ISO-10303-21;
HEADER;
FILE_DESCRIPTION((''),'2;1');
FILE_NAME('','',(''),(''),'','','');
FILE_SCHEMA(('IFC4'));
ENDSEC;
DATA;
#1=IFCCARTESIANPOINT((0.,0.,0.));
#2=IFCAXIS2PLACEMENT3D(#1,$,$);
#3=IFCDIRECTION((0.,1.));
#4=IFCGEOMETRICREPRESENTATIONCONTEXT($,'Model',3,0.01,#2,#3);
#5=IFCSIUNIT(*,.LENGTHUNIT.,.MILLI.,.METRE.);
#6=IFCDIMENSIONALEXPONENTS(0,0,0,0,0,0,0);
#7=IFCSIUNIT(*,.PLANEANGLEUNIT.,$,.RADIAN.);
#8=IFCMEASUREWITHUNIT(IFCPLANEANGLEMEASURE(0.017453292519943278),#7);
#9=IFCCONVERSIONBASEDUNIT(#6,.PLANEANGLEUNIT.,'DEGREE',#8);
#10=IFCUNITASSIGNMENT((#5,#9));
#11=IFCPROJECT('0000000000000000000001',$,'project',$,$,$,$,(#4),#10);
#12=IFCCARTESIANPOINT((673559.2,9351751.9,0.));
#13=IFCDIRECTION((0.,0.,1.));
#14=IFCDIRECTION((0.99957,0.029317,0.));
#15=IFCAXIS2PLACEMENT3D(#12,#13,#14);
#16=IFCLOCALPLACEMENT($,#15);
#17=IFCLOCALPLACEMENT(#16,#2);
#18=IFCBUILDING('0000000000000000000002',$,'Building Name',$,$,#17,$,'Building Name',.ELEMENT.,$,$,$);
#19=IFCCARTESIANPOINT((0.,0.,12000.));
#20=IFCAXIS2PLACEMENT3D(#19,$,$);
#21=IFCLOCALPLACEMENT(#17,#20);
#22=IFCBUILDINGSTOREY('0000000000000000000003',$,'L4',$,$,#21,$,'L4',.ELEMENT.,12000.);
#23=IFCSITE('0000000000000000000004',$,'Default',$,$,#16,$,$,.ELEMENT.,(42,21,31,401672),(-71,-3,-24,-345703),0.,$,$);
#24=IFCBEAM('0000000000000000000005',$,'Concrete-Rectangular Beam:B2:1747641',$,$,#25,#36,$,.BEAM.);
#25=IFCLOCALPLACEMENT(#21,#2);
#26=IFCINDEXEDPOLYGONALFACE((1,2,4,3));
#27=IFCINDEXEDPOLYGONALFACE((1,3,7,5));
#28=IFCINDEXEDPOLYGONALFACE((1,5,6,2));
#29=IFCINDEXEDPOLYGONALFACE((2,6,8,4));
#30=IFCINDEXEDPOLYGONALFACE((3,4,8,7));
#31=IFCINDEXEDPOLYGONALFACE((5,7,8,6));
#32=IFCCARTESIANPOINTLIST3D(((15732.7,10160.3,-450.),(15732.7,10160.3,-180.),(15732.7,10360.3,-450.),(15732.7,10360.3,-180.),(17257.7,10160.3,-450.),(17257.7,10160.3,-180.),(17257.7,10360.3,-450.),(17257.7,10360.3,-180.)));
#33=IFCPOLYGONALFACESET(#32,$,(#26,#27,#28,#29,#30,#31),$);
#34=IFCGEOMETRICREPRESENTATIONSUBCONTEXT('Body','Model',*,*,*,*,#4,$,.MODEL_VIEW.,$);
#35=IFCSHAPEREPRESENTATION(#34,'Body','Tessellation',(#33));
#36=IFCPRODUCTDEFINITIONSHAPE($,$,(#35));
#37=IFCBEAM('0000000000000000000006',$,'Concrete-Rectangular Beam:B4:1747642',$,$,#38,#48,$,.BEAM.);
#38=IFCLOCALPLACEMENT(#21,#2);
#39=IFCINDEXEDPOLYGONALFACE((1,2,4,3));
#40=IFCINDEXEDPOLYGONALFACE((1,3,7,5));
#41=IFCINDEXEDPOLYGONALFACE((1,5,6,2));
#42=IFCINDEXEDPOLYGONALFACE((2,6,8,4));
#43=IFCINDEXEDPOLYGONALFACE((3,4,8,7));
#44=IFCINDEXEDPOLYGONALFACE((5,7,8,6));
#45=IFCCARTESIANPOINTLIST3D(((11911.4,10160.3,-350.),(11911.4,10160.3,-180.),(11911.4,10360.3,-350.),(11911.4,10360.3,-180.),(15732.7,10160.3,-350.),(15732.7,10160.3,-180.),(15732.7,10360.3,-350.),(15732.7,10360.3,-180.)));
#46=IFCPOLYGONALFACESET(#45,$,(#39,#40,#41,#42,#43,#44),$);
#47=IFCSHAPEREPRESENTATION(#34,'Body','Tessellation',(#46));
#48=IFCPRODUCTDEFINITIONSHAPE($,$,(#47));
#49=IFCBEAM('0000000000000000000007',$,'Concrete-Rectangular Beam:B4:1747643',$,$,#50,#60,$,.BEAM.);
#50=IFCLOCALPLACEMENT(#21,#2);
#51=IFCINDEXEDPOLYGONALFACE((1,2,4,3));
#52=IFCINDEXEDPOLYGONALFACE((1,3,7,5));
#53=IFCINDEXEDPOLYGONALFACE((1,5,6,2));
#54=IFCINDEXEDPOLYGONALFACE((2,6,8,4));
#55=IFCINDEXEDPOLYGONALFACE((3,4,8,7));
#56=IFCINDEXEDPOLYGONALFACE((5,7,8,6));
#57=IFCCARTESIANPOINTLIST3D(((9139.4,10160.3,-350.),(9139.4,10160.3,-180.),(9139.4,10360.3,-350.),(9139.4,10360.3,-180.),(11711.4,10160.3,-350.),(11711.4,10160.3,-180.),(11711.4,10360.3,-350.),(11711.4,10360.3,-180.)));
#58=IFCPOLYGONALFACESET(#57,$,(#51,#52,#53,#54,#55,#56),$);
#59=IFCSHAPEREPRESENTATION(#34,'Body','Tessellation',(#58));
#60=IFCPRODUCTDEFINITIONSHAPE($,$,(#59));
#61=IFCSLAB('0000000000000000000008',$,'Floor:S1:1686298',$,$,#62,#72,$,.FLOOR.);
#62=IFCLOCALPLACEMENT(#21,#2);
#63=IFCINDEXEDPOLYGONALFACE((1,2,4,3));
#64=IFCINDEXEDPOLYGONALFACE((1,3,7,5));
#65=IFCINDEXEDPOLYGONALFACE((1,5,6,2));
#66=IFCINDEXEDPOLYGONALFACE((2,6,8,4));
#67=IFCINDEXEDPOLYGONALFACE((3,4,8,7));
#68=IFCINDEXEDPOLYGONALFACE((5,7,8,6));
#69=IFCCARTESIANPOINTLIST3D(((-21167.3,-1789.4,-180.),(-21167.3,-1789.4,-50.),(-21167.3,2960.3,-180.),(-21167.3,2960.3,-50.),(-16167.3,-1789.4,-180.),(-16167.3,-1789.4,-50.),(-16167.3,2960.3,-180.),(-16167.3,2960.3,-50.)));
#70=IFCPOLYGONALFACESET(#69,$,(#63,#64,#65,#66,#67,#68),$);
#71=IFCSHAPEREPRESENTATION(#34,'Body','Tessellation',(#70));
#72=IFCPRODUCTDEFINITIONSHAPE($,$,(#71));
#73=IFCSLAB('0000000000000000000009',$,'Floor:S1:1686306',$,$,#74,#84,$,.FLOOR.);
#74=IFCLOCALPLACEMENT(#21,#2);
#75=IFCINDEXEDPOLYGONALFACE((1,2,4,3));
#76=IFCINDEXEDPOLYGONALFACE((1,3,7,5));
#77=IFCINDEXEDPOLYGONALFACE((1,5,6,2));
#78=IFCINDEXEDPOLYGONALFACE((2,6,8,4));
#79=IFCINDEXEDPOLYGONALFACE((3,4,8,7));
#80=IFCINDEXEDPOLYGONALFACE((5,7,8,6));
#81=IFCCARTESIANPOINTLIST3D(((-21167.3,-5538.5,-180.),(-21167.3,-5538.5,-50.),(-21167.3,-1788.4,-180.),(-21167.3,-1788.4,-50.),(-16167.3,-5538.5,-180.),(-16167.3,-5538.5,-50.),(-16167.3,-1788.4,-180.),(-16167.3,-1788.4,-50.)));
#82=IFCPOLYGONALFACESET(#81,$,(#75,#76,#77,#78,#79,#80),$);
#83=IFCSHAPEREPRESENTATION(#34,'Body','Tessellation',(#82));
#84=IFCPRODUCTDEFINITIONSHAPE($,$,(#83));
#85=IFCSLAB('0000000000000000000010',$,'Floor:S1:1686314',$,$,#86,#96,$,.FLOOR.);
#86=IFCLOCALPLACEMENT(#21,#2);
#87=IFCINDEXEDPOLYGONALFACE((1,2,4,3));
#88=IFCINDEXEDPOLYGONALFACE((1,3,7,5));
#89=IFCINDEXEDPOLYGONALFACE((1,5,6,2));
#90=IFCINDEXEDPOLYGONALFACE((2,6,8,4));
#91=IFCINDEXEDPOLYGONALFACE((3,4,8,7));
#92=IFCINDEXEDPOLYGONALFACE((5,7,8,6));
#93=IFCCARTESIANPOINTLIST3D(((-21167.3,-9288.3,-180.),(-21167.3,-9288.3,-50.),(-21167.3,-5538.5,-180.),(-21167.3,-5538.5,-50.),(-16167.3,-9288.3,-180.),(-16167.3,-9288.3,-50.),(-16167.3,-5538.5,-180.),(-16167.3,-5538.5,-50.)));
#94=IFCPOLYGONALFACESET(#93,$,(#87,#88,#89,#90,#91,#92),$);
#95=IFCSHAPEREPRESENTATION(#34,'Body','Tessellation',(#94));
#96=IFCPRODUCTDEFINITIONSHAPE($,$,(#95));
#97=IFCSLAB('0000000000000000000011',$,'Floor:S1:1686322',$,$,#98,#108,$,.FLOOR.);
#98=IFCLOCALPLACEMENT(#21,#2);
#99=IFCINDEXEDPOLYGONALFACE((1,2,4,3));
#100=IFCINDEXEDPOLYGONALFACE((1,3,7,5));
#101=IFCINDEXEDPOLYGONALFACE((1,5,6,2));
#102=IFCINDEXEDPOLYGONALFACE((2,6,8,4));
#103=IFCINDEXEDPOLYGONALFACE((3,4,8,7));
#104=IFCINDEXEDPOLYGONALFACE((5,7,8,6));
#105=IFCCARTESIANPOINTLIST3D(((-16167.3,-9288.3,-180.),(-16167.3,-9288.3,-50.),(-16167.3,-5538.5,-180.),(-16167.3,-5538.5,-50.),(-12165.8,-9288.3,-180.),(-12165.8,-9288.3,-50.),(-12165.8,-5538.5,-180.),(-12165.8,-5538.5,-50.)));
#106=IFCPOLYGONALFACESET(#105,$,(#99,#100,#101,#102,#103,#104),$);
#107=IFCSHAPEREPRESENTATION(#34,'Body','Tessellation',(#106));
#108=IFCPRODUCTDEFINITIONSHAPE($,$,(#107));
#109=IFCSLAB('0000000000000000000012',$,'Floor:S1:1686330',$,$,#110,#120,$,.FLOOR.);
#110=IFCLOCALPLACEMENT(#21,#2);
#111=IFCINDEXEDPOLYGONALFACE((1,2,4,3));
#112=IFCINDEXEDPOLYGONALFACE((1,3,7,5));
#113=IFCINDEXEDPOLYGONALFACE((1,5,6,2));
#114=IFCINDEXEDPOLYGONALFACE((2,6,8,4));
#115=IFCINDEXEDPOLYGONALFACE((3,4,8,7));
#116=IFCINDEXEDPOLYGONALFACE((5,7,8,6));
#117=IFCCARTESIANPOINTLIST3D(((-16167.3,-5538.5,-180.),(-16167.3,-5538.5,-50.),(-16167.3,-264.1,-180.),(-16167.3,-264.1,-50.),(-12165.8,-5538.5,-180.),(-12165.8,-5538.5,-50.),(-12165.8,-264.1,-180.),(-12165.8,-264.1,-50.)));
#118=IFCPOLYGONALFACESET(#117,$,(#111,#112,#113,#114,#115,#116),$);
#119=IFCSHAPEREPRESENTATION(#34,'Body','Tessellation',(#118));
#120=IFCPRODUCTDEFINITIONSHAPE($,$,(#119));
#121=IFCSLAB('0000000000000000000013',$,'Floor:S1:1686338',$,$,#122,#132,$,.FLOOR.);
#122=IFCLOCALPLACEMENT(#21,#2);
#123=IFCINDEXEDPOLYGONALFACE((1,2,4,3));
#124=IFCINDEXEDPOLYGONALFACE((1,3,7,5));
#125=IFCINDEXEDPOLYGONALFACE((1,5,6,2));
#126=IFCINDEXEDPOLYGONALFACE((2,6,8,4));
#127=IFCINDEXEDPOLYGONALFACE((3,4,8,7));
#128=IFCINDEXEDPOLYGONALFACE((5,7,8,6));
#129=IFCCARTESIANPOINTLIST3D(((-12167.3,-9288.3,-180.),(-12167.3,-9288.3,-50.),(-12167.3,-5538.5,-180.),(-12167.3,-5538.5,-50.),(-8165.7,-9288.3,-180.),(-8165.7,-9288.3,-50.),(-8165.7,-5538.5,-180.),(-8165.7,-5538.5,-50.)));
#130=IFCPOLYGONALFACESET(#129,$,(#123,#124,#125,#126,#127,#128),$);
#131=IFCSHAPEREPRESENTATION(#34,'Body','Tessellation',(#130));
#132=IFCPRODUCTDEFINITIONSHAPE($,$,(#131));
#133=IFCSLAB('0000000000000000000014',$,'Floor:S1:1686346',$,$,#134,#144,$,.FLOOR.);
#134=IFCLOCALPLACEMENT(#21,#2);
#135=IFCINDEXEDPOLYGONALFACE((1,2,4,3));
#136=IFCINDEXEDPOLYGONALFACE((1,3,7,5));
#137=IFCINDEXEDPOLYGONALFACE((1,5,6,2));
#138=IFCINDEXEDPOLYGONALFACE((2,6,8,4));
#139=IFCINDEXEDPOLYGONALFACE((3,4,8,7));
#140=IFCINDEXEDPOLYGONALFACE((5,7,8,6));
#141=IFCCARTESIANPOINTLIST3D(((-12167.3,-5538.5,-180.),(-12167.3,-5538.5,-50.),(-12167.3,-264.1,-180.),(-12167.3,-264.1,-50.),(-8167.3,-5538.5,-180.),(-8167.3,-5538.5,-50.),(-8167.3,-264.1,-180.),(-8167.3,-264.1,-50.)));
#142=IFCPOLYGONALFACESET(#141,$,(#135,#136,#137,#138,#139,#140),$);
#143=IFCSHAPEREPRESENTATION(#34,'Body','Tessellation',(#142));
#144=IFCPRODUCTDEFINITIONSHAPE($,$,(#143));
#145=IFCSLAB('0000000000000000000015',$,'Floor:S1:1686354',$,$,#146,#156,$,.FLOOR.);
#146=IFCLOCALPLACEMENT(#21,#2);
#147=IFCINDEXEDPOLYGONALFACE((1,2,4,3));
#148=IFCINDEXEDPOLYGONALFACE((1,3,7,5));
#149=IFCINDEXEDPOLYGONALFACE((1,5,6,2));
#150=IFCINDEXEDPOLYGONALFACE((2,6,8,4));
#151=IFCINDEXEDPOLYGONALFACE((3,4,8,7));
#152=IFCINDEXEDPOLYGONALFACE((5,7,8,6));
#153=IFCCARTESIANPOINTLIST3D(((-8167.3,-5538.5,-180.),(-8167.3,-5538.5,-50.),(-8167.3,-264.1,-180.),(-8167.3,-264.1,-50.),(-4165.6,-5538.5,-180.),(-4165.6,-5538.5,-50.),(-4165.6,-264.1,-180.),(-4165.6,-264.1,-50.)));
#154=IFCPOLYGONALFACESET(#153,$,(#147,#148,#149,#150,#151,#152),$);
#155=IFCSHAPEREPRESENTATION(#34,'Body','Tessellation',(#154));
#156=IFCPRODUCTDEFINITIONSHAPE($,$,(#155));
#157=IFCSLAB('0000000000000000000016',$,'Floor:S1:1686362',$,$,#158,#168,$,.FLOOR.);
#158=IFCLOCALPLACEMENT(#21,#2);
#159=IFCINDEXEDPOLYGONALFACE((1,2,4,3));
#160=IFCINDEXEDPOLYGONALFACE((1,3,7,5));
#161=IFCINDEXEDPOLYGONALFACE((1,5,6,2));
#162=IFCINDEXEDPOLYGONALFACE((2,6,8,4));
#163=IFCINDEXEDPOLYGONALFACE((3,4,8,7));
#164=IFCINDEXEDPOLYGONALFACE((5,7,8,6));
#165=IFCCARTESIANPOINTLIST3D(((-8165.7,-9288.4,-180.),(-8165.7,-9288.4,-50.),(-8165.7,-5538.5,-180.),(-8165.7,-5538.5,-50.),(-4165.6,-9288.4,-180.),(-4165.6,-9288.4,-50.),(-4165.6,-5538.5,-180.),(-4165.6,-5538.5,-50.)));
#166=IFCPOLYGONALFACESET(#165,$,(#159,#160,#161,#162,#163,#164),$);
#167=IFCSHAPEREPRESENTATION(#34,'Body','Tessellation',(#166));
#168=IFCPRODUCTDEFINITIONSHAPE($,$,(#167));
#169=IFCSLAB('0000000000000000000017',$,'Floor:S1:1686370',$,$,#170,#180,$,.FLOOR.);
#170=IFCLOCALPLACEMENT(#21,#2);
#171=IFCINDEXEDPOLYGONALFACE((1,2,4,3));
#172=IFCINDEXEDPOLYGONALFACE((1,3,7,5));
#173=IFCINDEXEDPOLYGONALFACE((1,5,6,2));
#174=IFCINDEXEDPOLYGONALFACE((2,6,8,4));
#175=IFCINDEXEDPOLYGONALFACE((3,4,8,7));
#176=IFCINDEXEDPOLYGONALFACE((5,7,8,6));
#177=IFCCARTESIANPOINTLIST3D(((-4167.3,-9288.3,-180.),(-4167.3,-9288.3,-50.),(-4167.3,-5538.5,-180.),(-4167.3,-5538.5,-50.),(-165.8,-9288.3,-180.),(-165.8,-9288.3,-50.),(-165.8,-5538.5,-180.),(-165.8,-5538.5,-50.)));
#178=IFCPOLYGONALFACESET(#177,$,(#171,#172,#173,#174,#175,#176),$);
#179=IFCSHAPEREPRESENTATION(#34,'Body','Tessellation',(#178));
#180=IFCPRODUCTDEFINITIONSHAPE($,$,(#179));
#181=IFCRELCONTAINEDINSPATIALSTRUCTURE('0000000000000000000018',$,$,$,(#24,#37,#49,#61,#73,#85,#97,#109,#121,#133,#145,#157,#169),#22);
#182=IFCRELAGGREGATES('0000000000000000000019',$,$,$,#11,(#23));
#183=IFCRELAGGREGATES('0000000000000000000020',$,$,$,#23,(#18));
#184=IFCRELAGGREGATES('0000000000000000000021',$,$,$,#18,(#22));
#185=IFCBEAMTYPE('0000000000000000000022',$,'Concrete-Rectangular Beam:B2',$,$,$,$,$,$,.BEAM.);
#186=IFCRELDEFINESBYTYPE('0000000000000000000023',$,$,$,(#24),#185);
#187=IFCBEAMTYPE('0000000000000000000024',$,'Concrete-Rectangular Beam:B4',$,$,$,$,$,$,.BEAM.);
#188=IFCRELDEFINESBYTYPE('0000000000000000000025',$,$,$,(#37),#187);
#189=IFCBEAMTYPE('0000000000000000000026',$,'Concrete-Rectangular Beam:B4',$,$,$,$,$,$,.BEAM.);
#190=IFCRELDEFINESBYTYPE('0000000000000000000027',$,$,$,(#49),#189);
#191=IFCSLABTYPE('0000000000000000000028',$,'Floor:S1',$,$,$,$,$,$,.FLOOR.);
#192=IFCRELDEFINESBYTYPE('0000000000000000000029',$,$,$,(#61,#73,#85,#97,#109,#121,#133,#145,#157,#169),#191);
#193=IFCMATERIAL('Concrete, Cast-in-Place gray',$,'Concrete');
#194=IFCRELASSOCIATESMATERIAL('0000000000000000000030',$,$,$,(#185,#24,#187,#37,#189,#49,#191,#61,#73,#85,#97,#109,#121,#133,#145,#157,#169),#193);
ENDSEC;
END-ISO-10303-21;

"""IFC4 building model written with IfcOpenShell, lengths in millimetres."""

from ifc_helpers import new_model, entity, si_unit, converted_unit, direction, frame, origin, place, context, subcontext, project, spatial, indexed_curve, outline, extrude, source, transform, mapped, material, type_object, type_shapes, element, save


model = new_model("IFC4")

# Units and contexts
model_context = context("Model", 3, precision=0.01, world=origin(), true_north=direction((0.0, 1.0)))
body_context = subcontext(model_context, "Body", "Model", "MODEL_VIEW")
ifc_project = project(units=[si_unit("LENGTHUNIT", "METRE", prefix="MILLI"), converted_unit("PLANEANGLEUNIT", "DEGREE", entity("IfcPlaneAngleMeasure", 0.017453292519943278), si_unit("PLANEANGLEUNIT", "RADIAN"), dimensions=[0, 0, 0, 0, 0, 0, 0])], contexts=[model_context])

# Site, building, storey
site_placement = place(None, frame((673559.2, 9351751.9, 0.0), z_axis=(0.0, 0.0, 1.0), x_axis=(0.99957, 0.029317, 0.0)))
site = spatial("IfcSite", under=ifc_project, at=site_placement, Name="Default", CompositionType="ELEMENT", RefLatitude=(42, 21, 31, 401672), RefLongitude=(-71, -3, -24, -345703), RefElevation=0.0)
building_placement = place(site_placement, origin())
building = spatial("IfcBuilding", under=site, at=building_placement, Name="Building Name", LongName="Building Name", CompositionType="ELEMENT")
storey_placement = place(building_placement, frame((0.0, 0.0, 12000.0)))
storey = spatial("IfcBuildingStorey", under=building, at=storey_placement, Name="L4", LongName="L4", CompositionType="ELEMENT", Elevation=12000.0)

# Beams
ifc_material_1 = material(Name="Concrete, Cast-in-Place gray", Category="Concrete")
beam_type_1 = type_object("IfcBeamType", Name="Concrete-Rectangular Beam:B2", PredefinedType="BEAM", material=ifc_material_1)
shared_shape_1 = source(origin(), body_context, "Body", "SweptSolid", [
    extrude(outline(indexed_curve([(-135.0, -100.0), (135.0, -100.0), (135.0, 100.0), (-135.0, 100.0), (-135.0, -100.0)], self_intersect=False)), frame((17257.7, 10260.3, 11685.0), z_axis=(-1.0, 0.0, 0.0), x_axis=(0.0, 0.0, -1.0)), (0.0, 0.0, 1.0), 1525.0),
])
type_shapes(beam_type_1, [shared_shape_1])
beam_1_placement = place(storey_placement, frame((0.0, 0.0, -12000.0)))
element("IfcBeam", 1, at=beam_1_placement, inside=storey, type_object=beam_type_1, material=ifc_material_1, Name="Concrete-Rectangular Beam:B2:1747641", PredefinedType="BEAM", context=body_context, shape_type="MappedRepresentation", body=[
    mapped(shared_shape_1, transform((0.0, 0.0, 0.0), scale=1.0)),
])
beam_type_2 = type_object("IfcBeamType", Name="Concrete-Rectangular Beam:B4", PredefinedType="BEAM", material=ifc_material_1)
shared_shape_2 = source(origin(), body_context, "Body", "SweptSolid", [
    extrude(outline(indexed_curve([(-85.0, -100.0), (85.0, -100.0), (85.0, 100.0), (-85.0, 100.0), (-85.0, -100.0)], self_intersect=False)), frame((15732.7, 10260.3, 11735.0), z_axis=(-1.0, 0.0, 0.0), x_axis=(0.0, 0.0, -1.0)), (0.0, 0.0, 1.0), 3821.2),
])
type_shapes(beam_type_2, [shared_shape_2])
beam_2_placement = place(storey_placement, frame((0.0, 0.0, -12000.0)))
element("IfcBeam", 2, at=beam_2_placement, inside=storey, type_object=beam_type_2, material=ifc_material_1, Name="Concrete-Rectangular Beam:B4:1747642", PredefinedType="BEAM", context=body_context, shape_type="MappedRepresentation", body=[
    mapped(shared_shape_2, transform((0.0, 0.0, 0.0), scale=1.0)),
])
beam_type_3 = type_object("IfcBeamType", Name="Concrete-Rectangular Beam:B4", PredefinedType="BEAM", material=ifc_material_1)
shared_shape_3 = source(origin(), body_context, "Body", "SweptSolid", [
    extrude(outline(indexed_curve([(-85.0, -100.0), (85.0, -100.0), (85.0, 100.0), (-85.0, 100.0), (-85.0, -100.0)], self_intersect=False)), frame((11711.4, 10260.3, 11735.0), z_axis=(-1.0, 0.0, 0.0), x_axis=(0.0, 0.0, -1.0)), (0.0, 0.0, 1.0), 2572.1),
])
type_shapes(beam_type_3, [shared_shape_3])
beam_3_placement = place(storey_placement, frame((0.0, 0.0, -12000.0)))
element("IfcBeam", 3, at=beam_3_placement, inside=storey, type_object=beam_type_3, material=ifc_material_1, Name="Concrete-Rectangular Beam:B4:1747643", PredefinedType="BEAM", context=body_context, shape_type="MappedRepresentation", body=[
    mapped(shared_shape_3, transform((0.0, 0.0, 0.0), scale=1.0)),
])

# Slabs
slab_type_1 = type_object("IfcSlabType", Name="Floor:S1", PredefinedType="FLOOR", material=ifc_material_1)
slab_1_placement = place(storey_placement, origin())
element("IfcSlab", 4, at=slab_1_placement, inside=storey, type_object=slab_type_1, material=ifc_material_1, Name="Floor:S1:1686298", PredefinedType="FLOOR", context=body_context, shape_type="SweptSolid", body=[
    extrude(outline(indexed_curve([(-2374.9, -2500.0), (2374.9, -2500.0), (2374.9, 2500.0), (-2374.9, 2500.0), (-2374.9, -2500.0)], self_intersect=False)), frame((-18667.3, 585.4, -50.0), z_axis=(0.0, 0.0, -1.0), x_axis=(0.0, 1.0, 0.0)), (0.0, 0.0, 1.0), 130.0),
])
slab_2_placement = place(storey_placement, origin())
element("IfcSlab", 5, at=slab_2_placement, inside=storey, type_object=slab_type_1, material=ifc_material_1, Name="Floor:S1:1686306", PredefinedType="FLOOR", context=body_context, shape_type="SweptSolid", body=[
    extrude(outline(indexed_curve([(-1875.1, -2500.0), (1875.1, -2500.0), (1875.1, 2500.0), (-1875.1, 2500.0), (-1875.1, -2500.0)], self_intersect=False)), frame((-18667.3, -3663.5, -50.0), z_axis=(0.0, 0.0, -1.0), x_axis=(0.0, 1.0, 0.0)), (0.0, 0.0, 1.0), 130.0),
])
slab_3_placement = place(storey_placement, origin())
element("IfcSlab", 6, at=slab_3_placement, inside=storey, type_object=slab_type_1, material=ifc_material_1, Name="Floor:S1:1686314", PredefinedType="FLOOR", context=body_context, shape_type="SweptSolid", body=[
    extrude(outline(indexed_curve([(-1874.9, -2500.0), (1874.9, -2500.0), (1874.9, 2500.0), (-1874.9, 2500.0), (-1874.9, -2500.0)], self_intersect=False)), frame((-18667.3, -7413.4, -50.0), z_axis=(0.0, 0.0, -1.0), x_axis=(0.0, 1.0, 0.0)), (0.0, 0.0, 1.0), 130.0),
])
slab_4_placement = place(storey_placement, origin())
element("IfcSlab", 7, at=slab_4_placement, inside=storey, type_object=slab_type_1, material=ifc_material_1, Name="Floor:S1:1686322", PredefinedType="FLOOR", context=body_context, shape_type="SweptSolid", body=[
    extrude(outline(indexed_curve([(-1874.9, -2000.8), (1874.9, -2000.8), (1874.9, 2000.8), (-1874.9, 2000.8), (-1874.9, -2000.8)], self_intersect=False)), frame((-14166.6, -7413.4, -50.0), z_axis=(0.0, 0.0, -1.0), x_axis=(0.0, 1.0, 0.0)), (0.0, 0.0, 1.0), 130.0),
])
slab_5_placement = place(storey_placement, origin())
element("IfcSlab", 8, at=slab_5_placement, inside=storey, type_object=slab_type_1, material=ifc_material_1, Name="Floor:S1:1686330", PredefinedType="FLOOR", context=body_context, shape_type="SweptSolid", body=[
    extrude(outline(indexed_curve([(-2637.2, -2000.8), (2637.2, -2000.8), (2637.2, 2000.8), (-2637.2, 2000.8), (-2637.2, -2000.8)], self_intersect=False)), frame((-14166.6, -2901.3, -50.0), z_axis=(0.0, 0.0, -1.0), x_axis=(0.0, 1.0, 0.0)), (0.0, 0.0, 1.0), 130.0),
])
slab_6_placement = place(storey_placement, origin())
element("IfcSlab", 9, at=slab_6_placement, inside=storey, type_object=slab_type_1, material=ifc_material_1, Name="Floor:S1:1686338", PredefinedType="FLOOR", context=body_context, shape_type="SweptSolid", body=[
    extrude(outline(indexed_curve([(-1874.9, -2000.8), (1874.9, -2000.8), (1874.9, 2000.8), (-1874.9, 2000.8), (-1874.9, -2000.8)], self_intersect=False)), frame((-10166.5, -7413.4, -50.0), z_axis=(0.0, 0.0, -1.0), x_axis=(0.0, 1.0, 0.0)), (0.0, 0.0, 1.0), 130.0),
])
slab_7_placement = place(storey_placement, origin())
element("IfcSlab", 10, at=slab_7_placement, inside=storey, type_object=slab_type_1, material=ifc_material_1, Name="Floor:S1:1686346", PredefinedType="FLOOR", context=body_context, shape_type="SweptSolid", body=[
    extrude(outline(indexed_curve([(-2637.2, -2000.0), (2637.2, -2000.0), (2637.2, 2000.0), (-2637.2, 2000.0), (-2637.2, -2000.0)], self_intersect=False)), frame((-10167.3, -2901.3, -50.0), z_axis=(0.0, 0.0, -1.0), x_axis=(0.0, 1.0, 0.0)), (0.0, 0.0, 1.0), 130.0),
])
slab_8_placement = place(storey_placement, origin())
element("IfcSlab", 11, at=slab_8_placement, inside=storey, type_object=slab_type_1, material=ifc_material_1, Name="Floor:S1:1686354", PredefinedType="FLOOR", context=body_context, shape_type="SweptSolid", body=[
    extrude(outline(indexed_curve([(-2637.2, -2000.9), (2637.2, -2000.9), (2637.2, 2000.9), (-2637.2, 2000.9), (-2637.2, -2000.9)], self_intersect=False)), frame((-6166.4, -2901.3, -50.0), z_axis=(0.0, 0.0, -1.0), x_axis=(0.0, 1.0, 0.0)), (0.0, 0.0, 1.0), 130.0),
])
slab_9_placement = place(storey_placement, origin())
element("IfcSlab", 12, at=slab_9_placement, inside=storey, type_object=slab_type_1, material=ifc_material_1, Name="Floor:S1:1686362", PredefinedType="FLOOR", context=body_context, shape_type="SweptSolid", body=[
    extrude(outline(indexed_curve([(-1874.9, -2000.1), (1874.9, -2000.1), (1874.9, 2000.1), (-1874.9, 2000.1), (-1874.9, -2000.1)], self_intersect=False)), frame((-6165.6, -7413.5, -50.0), z_axis=(0.0, 0.0, -1.0), x_axis=(0.0, 1.0, 0.0)), (0.0, 0.0, 1.0), 130.0),
])
slab_10_placement = place(storey_placement, origin())
element("IfcSlab", 13, at=slab_10_placement, inside=storey, type_object=slab_type_1, material=ifc_material_1, Name="Floor:S1:1686370", PredefinedType="FLOOR", context=body_context, shape_type="SweptSolid", body=[
    extrude(outline(indexed_curve([(-1874.9, -2000.8), (1874.9, -2000.8), (1874.9, 2000.8), (-1874.9, 2000.8), (-1874.9, -2000.8)], self_intersect=False)), frame((-2166.6, -7413.4, -50.0), z_axis=(0.0, 0.0, -1.0), x_axis=(0.0, 1.0, 0.0)), (0.0, 0.0, 1.0), 130.0),
])

save(model, "model.ifc")
